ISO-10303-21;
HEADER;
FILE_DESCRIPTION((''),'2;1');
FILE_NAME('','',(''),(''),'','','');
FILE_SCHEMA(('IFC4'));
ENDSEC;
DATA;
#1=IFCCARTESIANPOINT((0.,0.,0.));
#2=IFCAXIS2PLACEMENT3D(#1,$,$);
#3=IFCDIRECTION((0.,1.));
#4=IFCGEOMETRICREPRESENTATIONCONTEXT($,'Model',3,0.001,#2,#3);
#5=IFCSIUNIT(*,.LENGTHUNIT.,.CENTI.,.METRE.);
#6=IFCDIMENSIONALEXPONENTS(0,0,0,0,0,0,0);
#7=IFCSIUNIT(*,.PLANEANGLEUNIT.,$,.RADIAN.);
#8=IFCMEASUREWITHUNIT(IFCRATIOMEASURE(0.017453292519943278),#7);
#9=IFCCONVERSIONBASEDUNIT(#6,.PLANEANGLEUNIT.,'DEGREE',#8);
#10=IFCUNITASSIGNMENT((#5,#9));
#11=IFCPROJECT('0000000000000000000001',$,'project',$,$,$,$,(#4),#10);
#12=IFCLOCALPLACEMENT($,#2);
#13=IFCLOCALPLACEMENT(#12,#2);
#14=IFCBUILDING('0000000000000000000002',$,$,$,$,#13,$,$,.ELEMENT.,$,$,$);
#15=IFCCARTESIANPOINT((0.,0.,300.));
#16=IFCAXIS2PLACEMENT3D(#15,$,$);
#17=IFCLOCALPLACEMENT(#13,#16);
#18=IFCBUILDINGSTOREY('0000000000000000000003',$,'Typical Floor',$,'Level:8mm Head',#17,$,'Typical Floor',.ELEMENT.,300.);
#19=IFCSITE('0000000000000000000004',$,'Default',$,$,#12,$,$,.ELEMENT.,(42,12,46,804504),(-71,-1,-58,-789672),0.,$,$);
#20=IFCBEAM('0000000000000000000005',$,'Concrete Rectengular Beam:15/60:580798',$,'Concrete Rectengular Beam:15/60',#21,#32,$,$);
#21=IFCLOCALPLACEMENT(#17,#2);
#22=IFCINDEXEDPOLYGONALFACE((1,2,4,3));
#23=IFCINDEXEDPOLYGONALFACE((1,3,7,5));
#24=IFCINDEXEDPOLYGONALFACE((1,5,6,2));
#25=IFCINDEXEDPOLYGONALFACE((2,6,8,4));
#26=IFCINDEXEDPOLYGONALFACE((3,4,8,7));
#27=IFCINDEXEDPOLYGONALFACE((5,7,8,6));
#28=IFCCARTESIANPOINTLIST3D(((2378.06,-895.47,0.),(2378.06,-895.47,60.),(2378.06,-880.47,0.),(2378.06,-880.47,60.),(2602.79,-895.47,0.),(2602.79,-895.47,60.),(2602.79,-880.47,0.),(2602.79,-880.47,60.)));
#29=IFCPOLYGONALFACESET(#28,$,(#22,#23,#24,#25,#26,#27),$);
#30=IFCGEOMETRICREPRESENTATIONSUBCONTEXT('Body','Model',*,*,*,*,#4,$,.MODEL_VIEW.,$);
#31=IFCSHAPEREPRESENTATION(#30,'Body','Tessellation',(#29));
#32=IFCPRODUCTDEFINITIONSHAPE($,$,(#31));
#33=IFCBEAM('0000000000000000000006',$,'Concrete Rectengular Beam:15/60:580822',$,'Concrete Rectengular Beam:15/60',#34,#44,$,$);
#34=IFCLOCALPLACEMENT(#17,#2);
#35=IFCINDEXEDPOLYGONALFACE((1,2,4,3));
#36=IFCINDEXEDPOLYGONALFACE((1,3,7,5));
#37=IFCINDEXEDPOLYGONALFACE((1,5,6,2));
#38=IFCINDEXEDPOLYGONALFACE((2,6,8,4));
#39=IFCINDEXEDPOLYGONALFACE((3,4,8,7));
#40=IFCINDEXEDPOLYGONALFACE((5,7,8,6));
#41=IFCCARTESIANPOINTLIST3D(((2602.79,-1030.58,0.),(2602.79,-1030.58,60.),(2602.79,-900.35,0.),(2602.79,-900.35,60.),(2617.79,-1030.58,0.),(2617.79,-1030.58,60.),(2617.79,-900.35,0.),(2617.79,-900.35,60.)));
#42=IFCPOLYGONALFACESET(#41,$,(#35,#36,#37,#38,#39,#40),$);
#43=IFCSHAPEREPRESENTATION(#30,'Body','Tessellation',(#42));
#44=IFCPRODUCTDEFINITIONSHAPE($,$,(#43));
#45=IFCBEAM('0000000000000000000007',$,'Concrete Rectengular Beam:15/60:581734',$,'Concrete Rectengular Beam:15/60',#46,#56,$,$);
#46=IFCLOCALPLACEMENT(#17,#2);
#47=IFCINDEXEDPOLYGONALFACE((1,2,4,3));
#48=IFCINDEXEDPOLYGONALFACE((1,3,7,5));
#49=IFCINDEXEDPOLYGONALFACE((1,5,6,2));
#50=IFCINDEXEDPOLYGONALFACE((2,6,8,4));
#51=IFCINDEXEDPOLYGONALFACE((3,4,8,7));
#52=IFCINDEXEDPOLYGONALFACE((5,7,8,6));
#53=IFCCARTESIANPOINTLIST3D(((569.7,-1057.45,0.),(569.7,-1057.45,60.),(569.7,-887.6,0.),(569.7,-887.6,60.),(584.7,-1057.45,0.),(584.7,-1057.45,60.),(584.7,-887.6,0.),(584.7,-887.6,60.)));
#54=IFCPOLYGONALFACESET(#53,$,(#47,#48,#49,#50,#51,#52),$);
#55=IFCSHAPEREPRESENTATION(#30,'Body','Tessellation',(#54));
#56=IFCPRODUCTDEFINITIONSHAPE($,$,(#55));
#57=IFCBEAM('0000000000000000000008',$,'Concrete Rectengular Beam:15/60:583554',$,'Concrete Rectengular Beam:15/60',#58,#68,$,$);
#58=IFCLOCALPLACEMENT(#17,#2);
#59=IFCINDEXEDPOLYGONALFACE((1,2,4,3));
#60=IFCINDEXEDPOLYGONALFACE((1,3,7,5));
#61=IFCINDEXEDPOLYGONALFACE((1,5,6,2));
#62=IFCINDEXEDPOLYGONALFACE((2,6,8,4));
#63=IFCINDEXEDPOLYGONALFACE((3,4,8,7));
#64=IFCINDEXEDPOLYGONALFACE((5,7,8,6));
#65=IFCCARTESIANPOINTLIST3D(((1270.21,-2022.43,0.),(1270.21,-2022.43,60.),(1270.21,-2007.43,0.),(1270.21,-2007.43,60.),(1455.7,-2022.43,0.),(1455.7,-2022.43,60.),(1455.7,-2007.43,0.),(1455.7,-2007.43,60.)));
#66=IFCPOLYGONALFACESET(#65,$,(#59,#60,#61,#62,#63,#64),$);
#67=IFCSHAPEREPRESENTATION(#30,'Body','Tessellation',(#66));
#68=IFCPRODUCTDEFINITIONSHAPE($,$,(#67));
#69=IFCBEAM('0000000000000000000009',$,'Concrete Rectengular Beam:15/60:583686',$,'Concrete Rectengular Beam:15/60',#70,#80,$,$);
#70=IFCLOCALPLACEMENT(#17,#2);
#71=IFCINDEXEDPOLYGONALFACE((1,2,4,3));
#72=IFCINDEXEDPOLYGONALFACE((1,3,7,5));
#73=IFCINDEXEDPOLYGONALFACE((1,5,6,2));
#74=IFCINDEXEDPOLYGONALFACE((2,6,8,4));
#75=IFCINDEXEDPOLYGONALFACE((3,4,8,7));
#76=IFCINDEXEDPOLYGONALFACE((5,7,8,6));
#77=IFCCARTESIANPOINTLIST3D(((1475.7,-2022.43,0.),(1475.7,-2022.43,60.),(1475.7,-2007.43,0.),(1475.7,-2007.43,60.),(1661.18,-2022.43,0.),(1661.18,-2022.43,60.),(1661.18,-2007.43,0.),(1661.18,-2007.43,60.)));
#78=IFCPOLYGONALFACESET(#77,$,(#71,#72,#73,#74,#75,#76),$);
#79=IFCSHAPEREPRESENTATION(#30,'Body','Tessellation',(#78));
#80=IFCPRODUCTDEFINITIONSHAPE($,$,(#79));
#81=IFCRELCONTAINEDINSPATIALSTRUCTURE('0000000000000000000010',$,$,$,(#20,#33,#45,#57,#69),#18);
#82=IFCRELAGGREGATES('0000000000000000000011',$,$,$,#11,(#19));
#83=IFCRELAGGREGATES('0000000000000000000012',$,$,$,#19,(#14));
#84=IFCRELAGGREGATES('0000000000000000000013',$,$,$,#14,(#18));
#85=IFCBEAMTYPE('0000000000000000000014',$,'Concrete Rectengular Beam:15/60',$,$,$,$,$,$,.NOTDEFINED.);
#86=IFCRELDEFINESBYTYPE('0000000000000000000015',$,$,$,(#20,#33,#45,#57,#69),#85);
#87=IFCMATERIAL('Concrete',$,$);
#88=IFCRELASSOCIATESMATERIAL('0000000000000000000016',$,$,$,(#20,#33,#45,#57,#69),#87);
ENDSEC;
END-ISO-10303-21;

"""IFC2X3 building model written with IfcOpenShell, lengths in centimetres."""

from ifc_helpers import new_model, entity, si_unit, converted_unit, direction, frame, frame_2d, origin, origin_2d_with_axis, place, context, subcontext, project, spatial, rectangle, extrude, material, type_object, element, save


model = new_model("IFC2X3")

# Units and contexts
model_context = context("Model", 3, precision=0.001, world=origin(), true_north=direction((0.0, 1.0)))
body_context = subcontext(model_context, "Body", "Model", "MODEL_VIEW")
ifc_project = project(units=[si_unit("LENGTHUNIT", "METRE", prefix="CENTI"), converted_unit("PLANEANGLEUNIT", "DEGREE", entity("IfcRatioMeasure", 0.017453292519943278), si_unit("PLANEANGLEUNIT", "RADIAN"), dimensions=[0, 0, 0, 0, 0, 0, 0])], contexts=[model_context])

# Site, building, storey
site_placement = place(None, origin())
site = spatial("IfcSite", under=ifc_project, at=site_placement, Name="Default", CompositionType="ELEMENT", RefLatitude=(42, 12, 46, 804504), RefLongitude=(-71, -1, -58, -789672), RefElevation=0.0)
building_placement = place(site_placement, origin())
building = spatial("IfcBuilding", under=site, at=building_placement, CompositionType="ELEMENT")
storey_placement = place(building_placement, frame((0.0, 0.0, 300.0)))
storey = spatial("IfcBuildingStorey", under=building, at=storey_placement, Name="Typical Floor", ObjectType="Level:8mm Head", LongName="Typical Floor", CompositionType="ELEMENT", Elevation=300.0)

# Beams
ifc_material = material(Name="Concrete")
beam_type_1 = type_object("IfcBeamType", Name="Concrete Rectengular Beam:15/60", PredefinedType="NOTDEFINED")
beam_1_placement = place(storey_placement, frame((2378.06, -887.97, 0.0)))
element("IfcBeam", 1, at=beam_1_placement, inside=storey, type_object=beam_type_1, material=ifc_material, Name="Concrete Rectengular Beam:15/60:580798", ObjectType="Concrete Rectengular Beam:15/60", context=body_context, shape_type="SweptSolid", body=[
    extrude(rectangle(XDim=60.0, YDim=15.0, at=frame_2d((0.0, 0.0), x_axis=(1.0, 0.0))), frame((0.0, 0.0, 30.0), z_axis=(1.0, 0.0, 0.0), x_axis=(0.0, 0.0, -1.0)), (0.0, 0.0, 1.0), 224.72),
])
beam_2_placement = place(storey_placement, frame((2610.29, -900.35, 0.0), z_axis=(0.0, 0.0, 1.0), x_axis=(0.0, -1.0, 0.0)))
element("IfcBeam", 2, at=beam_2_placement, inside=storey, type_object=beam_type_1, material=ifc_material, Name="Concrete Rectengular Beam:15/60:580822", ObjectType="Concrete Rectengular Beam:15/60", context=body_context, shape_type="SweptSolid", body=[
    extrude(rectangle(XDim=60.0, YDim=15.0, at=origin_2d_with_axis()), frame((0.0, 0.0, 30.0), z_axis=(1.0, 0.0, 0.0), x_axis=(0.0, 0.0, -1.0)), (0.0, 0.0, 1.0), 130.23),
])
beam_3_placement = place(storey_placement, frame((577.2, -1057.45, 0.0), z_axis=(0.0, 0.0, 1.0), x_axis=(0.0, 1.0, 0.0)))
element("IfcBeam", 3, at=beam_3_placement, inside=storey, type_object=beam_type_1, material=ifc_material, Name="Concrete Rectengular Beam:15/60:581734", ObjectType="Concrete Rectengular Beam:15/60", context=body_context, shape_type="SweptSolid", body=[
    extrude(rectangle(XDim=60.0, YDim=15.0, at=frame_2d((0.0, 0.0), x_axis=(1.0, 0.0))), frame((0.0, 0.0, 30.0), z_axis=(1.0, 0.0, 0.0), x_axis=(0.0, 0.0, -1.0)), (0.0, 0.0, 1.0), 169.86),
])
for number, where, name in (
    (4, (1270.21, -2014.93, 0.0), "Concrete Rectengular Beam:15/60:583554"),
    (5, (1475.7, -2014.93, 0.0), "Concrete Rectengular Beam:15/60:583686"),
):
    element("IfcBeam", number, at=place(storey_placement, frame(where)), inside=storey, type_object=beam_type_1, material=ifc_material, Name=name, ObjectType="Concrete Rectengular Beam:15/60", context=body_context, shape_type="SweptSolid", body=[
        extrude(rectangle(XDim=60.0, YDim=15.0, at=frame_2d((0.0, 0.0), x_axis=(1.0, 0.0))), frame((0.0, 0.0, 30.0), z_axis=(1.0, 0.0, 0.0), x_axis=(0.0, 0.0, -1.0)), (0.0, 0.0, 1.0), 185.48),
    ])

save(model, "model.ifc")
